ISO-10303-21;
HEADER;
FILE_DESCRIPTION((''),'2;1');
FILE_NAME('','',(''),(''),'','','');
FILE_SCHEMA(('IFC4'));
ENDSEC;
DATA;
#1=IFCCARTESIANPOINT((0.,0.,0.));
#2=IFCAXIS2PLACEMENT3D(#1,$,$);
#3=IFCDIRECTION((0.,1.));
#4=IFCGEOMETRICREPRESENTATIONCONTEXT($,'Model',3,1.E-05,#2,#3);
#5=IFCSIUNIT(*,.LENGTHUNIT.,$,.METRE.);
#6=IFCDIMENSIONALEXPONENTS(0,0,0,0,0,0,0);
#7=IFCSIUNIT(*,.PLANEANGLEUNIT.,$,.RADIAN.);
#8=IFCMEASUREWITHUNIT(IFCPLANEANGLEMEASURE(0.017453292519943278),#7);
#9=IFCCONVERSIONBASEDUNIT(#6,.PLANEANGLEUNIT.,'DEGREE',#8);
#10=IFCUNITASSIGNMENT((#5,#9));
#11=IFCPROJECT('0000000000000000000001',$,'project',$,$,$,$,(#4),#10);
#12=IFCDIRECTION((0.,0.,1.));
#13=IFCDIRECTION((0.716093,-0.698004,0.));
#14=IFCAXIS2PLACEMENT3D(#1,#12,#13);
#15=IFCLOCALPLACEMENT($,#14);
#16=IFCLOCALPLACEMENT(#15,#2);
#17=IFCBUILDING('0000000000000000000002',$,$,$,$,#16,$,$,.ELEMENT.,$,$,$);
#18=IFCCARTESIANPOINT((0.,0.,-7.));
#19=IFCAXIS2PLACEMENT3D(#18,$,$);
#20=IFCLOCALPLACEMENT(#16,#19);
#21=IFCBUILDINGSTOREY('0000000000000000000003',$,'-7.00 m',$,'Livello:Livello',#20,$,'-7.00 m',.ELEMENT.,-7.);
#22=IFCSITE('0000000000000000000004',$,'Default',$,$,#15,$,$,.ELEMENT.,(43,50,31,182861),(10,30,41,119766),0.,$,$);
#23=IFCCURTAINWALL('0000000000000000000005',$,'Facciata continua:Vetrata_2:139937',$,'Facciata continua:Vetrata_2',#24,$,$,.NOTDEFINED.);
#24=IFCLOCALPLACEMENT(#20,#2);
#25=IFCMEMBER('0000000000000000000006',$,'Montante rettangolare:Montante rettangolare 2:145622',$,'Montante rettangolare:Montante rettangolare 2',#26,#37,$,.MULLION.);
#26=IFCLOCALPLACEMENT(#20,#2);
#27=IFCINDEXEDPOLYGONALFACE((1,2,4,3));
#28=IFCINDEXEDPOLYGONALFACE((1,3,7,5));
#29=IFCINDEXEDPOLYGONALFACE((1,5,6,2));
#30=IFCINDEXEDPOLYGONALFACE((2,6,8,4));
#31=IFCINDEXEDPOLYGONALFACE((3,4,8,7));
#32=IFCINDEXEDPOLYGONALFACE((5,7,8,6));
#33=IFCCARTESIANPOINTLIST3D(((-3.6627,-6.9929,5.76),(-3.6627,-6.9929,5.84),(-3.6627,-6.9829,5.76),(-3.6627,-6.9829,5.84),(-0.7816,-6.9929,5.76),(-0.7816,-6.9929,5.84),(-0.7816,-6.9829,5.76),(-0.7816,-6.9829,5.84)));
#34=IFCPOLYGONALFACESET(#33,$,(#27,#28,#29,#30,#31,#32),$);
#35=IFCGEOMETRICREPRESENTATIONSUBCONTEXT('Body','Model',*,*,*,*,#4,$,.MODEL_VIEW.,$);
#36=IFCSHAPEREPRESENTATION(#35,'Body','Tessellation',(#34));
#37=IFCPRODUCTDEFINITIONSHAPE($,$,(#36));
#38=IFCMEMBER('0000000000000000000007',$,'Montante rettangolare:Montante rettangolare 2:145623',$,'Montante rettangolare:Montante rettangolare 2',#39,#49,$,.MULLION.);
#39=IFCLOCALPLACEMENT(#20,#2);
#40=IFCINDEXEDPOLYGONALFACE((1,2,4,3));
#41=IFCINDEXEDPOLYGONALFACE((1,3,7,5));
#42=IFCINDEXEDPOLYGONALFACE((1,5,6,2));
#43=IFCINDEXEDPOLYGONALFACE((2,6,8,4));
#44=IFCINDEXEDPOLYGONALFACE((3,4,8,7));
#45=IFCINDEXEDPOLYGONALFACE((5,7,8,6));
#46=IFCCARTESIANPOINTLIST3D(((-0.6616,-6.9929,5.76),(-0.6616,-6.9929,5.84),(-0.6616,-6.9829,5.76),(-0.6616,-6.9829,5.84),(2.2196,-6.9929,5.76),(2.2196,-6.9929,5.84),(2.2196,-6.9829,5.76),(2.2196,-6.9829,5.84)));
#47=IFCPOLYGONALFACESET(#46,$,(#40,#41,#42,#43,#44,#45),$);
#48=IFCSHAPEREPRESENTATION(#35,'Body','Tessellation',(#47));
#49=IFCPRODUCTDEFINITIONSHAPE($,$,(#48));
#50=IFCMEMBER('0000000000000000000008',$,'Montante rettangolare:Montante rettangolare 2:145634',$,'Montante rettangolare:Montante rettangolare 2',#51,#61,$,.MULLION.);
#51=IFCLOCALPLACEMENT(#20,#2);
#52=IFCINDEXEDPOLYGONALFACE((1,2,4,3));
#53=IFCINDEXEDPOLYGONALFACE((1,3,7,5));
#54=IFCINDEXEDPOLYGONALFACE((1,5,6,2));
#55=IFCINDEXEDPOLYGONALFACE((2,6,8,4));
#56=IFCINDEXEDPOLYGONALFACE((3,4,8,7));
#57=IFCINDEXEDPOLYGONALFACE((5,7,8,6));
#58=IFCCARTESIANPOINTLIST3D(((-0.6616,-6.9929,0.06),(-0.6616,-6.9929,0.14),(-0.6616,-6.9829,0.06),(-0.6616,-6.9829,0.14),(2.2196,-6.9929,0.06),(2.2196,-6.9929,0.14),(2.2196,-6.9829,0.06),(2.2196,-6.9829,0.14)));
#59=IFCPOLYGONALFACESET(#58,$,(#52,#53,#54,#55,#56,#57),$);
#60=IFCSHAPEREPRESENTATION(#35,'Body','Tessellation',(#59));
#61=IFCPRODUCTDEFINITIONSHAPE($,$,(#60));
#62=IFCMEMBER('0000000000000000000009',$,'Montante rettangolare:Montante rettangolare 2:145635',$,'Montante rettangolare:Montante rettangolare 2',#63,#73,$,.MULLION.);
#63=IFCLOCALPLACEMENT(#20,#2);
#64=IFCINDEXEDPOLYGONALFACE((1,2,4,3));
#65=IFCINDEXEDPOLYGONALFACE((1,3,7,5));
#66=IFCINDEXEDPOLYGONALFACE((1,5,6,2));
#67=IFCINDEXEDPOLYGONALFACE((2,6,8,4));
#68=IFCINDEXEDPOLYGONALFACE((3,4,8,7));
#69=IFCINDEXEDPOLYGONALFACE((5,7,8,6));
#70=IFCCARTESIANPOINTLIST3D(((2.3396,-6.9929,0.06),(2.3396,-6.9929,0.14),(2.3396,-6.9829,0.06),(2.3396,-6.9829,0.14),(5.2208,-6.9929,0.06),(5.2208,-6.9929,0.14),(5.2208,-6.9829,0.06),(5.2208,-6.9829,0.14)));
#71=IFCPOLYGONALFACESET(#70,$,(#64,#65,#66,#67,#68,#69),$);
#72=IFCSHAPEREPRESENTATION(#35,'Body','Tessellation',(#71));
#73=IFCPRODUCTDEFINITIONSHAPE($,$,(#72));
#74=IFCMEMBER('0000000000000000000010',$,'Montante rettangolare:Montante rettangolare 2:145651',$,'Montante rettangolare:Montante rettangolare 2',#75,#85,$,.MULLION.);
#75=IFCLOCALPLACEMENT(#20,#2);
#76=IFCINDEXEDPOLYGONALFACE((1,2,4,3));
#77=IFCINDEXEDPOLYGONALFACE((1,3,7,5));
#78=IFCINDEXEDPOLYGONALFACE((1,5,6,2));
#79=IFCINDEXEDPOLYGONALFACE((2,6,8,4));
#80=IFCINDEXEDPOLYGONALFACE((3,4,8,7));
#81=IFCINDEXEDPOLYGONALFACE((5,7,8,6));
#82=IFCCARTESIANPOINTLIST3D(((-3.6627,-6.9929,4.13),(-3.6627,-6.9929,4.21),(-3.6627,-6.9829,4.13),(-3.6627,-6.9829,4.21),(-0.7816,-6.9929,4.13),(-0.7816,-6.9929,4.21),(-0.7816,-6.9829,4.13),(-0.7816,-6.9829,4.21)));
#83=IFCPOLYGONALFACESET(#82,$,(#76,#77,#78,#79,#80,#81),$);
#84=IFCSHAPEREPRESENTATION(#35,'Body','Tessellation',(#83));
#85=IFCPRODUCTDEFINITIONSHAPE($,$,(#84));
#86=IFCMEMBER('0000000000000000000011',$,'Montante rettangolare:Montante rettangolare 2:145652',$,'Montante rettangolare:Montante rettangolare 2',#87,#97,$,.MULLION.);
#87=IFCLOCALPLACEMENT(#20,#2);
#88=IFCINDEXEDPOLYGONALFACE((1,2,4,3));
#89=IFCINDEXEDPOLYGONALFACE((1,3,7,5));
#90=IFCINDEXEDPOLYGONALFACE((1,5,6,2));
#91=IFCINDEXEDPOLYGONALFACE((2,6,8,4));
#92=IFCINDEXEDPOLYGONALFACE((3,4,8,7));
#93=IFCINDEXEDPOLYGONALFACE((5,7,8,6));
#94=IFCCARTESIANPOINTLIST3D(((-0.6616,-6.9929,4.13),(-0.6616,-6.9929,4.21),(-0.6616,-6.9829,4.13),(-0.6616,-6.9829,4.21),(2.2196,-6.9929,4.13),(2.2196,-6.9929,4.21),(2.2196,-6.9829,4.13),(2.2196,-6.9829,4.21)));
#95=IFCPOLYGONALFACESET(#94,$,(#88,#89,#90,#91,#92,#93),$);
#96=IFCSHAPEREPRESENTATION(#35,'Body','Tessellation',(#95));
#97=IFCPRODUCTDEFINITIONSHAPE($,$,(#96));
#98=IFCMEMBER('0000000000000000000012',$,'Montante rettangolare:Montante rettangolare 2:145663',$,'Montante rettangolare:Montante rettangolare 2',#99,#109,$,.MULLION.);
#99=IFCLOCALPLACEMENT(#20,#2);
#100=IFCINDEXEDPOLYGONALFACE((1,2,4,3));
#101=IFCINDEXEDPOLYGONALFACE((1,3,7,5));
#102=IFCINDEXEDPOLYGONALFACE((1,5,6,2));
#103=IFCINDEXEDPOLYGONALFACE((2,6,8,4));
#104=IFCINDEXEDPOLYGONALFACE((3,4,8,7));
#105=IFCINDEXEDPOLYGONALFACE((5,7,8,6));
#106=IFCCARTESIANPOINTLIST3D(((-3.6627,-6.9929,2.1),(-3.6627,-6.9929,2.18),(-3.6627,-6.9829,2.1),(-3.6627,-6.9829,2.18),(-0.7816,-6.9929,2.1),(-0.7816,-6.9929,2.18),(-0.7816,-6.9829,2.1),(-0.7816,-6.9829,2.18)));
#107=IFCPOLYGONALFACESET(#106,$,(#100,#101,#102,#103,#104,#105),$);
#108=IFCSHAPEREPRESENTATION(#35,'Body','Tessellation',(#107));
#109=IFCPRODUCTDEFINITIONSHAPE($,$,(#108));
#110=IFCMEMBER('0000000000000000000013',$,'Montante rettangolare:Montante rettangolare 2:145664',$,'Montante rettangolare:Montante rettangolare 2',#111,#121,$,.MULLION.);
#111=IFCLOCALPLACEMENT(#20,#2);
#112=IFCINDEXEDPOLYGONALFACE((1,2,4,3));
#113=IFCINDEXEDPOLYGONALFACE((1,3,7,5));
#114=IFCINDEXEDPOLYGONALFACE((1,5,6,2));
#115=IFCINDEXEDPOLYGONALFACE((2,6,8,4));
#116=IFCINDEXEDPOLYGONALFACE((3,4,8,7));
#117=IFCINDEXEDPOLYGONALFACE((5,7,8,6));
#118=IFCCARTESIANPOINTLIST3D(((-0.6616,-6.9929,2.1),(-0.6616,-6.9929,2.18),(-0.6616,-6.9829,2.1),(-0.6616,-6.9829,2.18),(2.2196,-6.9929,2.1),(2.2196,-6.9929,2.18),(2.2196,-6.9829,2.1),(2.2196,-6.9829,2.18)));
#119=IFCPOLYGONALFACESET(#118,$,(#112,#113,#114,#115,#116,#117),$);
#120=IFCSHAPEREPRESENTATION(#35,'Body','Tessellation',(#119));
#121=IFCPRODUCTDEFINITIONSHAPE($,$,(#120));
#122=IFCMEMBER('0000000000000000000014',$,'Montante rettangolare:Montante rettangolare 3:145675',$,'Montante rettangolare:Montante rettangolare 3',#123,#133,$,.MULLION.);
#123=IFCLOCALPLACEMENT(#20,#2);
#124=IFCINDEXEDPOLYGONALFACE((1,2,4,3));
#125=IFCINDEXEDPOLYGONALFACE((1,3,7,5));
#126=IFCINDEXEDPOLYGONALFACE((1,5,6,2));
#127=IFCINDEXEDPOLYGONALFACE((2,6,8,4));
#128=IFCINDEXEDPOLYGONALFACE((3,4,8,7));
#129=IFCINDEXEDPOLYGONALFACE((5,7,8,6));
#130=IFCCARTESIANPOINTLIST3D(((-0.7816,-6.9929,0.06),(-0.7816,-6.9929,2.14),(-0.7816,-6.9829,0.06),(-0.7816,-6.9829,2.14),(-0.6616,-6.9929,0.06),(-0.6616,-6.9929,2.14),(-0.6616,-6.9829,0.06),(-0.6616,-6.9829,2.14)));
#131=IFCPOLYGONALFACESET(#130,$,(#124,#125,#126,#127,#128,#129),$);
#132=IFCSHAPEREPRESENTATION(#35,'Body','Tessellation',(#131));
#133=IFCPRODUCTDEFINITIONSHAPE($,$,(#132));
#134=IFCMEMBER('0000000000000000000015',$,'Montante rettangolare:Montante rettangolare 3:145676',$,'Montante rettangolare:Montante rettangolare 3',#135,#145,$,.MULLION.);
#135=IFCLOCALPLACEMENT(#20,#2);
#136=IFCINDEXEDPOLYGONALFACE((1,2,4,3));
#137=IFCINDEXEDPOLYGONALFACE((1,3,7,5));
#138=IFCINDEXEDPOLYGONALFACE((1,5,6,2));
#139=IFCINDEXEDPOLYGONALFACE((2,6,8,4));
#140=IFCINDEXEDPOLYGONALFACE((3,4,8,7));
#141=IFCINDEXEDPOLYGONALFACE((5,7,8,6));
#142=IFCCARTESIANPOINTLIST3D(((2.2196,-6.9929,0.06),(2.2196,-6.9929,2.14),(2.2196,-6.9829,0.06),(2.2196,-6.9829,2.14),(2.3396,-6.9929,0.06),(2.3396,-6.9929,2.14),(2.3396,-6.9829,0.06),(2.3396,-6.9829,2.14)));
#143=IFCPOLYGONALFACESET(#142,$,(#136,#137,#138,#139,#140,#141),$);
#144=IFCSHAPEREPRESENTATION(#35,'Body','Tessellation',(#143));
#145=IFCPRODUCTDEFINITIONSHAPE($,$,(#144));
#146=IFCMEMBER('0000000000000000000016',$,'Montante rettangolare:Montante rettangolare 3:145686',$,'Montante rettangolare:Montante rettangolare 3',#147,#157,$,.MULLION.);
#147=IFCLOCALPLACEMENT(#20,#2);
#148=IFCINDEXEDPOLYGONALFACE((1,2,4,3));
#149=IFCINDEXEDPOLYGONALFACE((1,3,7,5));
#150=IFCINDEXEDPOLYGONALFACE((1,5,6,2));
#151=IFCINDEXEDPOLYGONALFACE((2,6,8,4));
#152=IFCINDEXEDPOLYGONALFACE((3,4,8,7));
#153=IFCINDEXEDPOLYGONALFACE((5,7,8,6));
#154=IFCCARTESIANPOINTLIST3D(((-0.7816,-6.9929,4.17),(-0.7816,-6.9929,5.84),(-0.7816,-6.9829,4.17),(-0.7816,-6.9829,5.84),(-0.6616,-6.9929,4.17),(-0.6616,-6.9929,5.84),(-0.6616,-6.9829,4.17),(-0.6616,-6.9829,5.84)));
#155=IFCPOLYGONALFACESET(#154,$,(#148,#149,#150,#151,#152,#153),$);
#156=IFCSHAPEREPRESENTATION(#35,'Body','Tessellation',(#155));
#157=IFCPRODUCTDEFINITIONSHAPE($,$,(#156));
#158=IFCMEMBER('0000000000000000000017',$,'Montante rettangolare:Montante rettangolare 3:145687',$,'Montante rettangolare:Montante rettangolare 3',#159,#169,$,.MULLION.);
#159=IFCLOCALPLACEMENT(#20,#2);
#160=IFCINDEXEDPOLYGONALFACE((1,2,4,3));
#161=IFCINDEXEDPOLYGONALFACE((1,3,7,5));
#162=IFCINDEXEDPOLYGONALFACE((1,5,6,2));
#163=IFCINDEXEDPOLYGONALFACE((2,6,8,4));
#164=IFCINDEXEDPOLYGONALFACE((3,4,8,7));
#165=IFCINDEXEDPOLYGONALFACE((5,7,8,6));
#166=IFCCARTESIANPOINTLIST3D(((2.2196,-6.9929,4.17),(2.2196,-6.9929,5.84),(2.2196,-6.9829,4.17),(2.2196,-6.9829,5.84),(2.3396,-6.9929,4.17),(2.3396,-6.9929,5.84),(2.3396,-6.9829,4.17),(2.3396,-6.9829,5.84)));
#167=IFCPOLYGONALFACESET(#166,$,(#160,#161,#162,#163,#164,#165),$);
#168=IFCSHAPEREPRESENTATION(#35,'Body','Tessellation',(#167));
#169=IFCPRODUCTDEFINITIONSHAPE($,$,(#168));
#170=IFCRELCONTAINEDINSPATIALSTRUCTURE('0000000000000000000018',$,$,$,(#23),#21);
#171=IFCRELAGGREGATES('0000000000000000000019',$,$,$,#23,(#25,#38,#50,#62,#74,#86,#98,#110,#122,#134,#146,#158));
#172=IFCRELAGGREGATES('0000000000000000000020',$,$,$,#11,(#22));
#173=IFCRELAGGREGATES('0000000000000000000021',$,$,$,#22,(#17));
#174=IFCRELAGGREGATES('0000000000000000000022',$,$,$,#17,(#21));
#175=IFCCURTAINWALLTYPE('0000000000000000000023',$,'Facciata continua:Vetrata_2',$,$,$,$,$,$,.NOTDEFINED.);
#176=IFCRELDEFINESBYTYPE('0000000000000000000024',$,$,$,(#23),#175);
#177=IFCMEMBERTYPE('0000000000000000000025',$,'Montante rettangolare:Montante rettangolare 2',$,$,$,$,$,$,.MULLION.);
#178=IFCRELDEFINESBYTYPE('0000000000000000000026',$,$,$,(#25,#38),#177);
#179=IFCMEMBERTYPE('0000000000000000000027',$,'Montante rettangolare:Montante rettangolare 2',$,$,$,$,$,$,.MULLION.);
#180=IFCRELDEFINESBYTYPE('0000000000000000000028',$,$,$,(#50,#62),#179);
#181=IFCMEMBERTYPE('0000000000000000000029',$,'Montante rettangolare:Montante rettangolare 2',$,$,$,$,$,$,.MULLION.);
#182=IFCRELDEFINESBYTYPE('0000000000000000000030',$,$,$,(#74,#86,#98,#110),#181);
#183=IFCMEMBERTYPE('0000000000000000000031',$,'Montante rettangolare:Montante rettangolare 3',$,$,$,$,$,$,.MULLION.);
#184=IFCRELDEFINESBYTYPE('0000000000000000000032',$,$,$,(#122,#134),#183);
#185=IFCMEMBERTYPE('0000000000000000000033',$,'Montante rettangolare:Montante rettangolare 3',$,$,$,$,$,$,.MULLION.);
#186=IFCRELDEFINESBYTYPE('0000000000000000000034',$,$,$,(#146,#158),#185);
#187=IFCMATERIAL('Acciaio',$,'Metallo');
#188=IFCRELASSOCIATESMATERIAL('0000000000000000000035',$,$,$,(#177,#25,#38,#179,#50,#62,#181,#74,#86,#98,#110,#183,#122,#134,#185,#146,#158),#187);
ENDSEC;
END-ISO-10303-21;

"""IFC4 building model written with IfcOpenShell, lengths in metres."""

from ifc_helpers import new_model, entity, si_unit, converted_unit, direction, frame, origin, place, context, subcontext, project, spatial, indexed_curve, outline, extrude, source, transform, mapped, material, type_object, type_shapes, element, aggregate, save


model = new_model("IFC4")

# Units and contexts
model_context = context("Model", 3, precision=1e-05, world=origin(), true_north=direction((0.0, 1.0)))
body_context = subcontext(model_context, "Body", "Model", "MODEL_VIEW")
ifc_project = project(units=[si_unit("LENGTHUNIT", "METRE"), converted_unit("PLANEANGLEUNIT", "DEGREE", entity("IfcPlaneAngleMeasure", 0.017453292519943278), si_unit("PLANEANGLEUNIT", "RADIAN"), dimensions=[0, 0, 0, 0, 0, 0, 0])], contexts=[model_context])

# Site, building, storey
site_placement = place(None, frame((0.0, 0.0, 0.0), z_axis=(0.0, 0.0, 1.0), x_axis=(0.716093, -0.698004, 0.0)))
site = spatial("IfcSite", under=ifc_project, at=site_placement, Name="Default", CompositionType="ELEMENT", RefLatitude=(43, 50, 31, 182861), RefLongitude=(10, 30, 41, 119766), RefElevation=0.0)
building_placement = place(site_placement, origin())
building = spatial("IfcBuilding", under=site, at=building_placement, CompositionType="ELEMENT")
storey_placement = place(building_placement, frame((0.0, 0.0, -7.0)))
storey = spatial("IfcBuildingStorey", under=building, at=storey_placement, Name="-7.00 m", ObjectType="Livello:Livello", LongName="-7.00 m", CompositionType="ELEMENT", Elevation=-7.0)

# Curtain wall, members
curtain_wall_type = type_object("IfcCurtainWallType", Name="Facciata continua:Vetrata_2", PredefinedType="NOTDEFINED")
curtain_wall_placement = place(storey_placement, frame((0.0, 0.0, 7.0)))
curtain_wall = element("IfcCurtainWall", 1, at=curtain_wall_placement, inside=storey, type_object=curtain_wall_type, Name="Facciata continua:Vetrata_2:139937", ObjectType="Facciata continua:Vetrata_2", PredefinedType="NOTDEFINED")
ifc_material_1 = material(Name="Acciaio", Category="Metallo")
member_type_1 = type_object("IfcMemberType", Name="Montante rettangolare:Montante rettangolare 2", PredefinedType="MULLION", material=ifc_material_1)
shared_shape_1 = source(origin(), body_context, "Body", "SweptSolid", [
    extrude(outline(indexed_curve([(-0.04, -0.005), (0.04, -0.005), (0.04, 0.005), (-0.04, 0.005), (-0.04, -0.005)], self_intersect=False)), frame((-0.04, 0.01, -2.8812), z_axis=(0.0, 0.0, 1.0), x_axis=(-1.0, 0.0, 0.0)), (0.0, 0.0, 1.0), 2.8812),
])
type_shapes(member_type_1, [shared_shape_1])
member_1_placement = place(curtain_wall_placement, frame((-0.7816, -6.9779, -1.16), z_axis=(1.0, 0.0, 0.0), x_axis=(0.0, 0.0, 1.0)))
member_1 = element("IfcMember", 2, at=member_1_placement, type_object=member_type_1, material=ifc_material_1, Name="Montante rettangolare:Montante rettangolare 2:145622", ObjectType="Montante rettangolare:Montante rettangolare 2", PredefinedType="MULLION", context=body_context, shape_type="MappedRepresentation", body=[
    mapped(shared_shape_1, transform((0.0, 0.0, 0.0), scale=1.0)),
])
member_2_placement = place(curtain_wall_placement, frame((2.2196, -6.9779, -1.16), z_axis=(1.0, 0.0, 0.0), x_axis=(0.0, 0.0, 1.0)))
member_2 = element("IfcMember", 3, at=member_2_placement, type_object=member_type_1, material=ifc_material_1, Name="Montante rettangolare:Montante rettangolare 2:145623", ObjectType="Montante rettangolare:Montante rettangolare 2", PredefinedType="MULLION", context=body_context, shape_type="MappedRepresentation", body=[
    mapped(shared_shape_1, transform((0.0, 0.0, 0.0), scale=1.0)),
])
member_type_2 = type_object("IfcMemberType", Name="Montante rettangolare:Montante rettangolare 2", PredefinedType="MULLION", material=ifc_material_1)
shared_shape_2 = source(origin(), body_context, "Body", "SweptSolid", [
    extrude(outline(indexed_curve([(-0.04, -0.005), (0.04, -0.005), (0.04, 0.005), (-0.04, 0.005), (-0.04, -0.005)], self_intersect=False)), frame((-0.04, 0.01, -2.8812), z_axis=(0.0, 0.0, 1.0), x_axis=(-1.0, 0.0, 0.0)), (0.0, 0.0, 1.0), 2.8812),
])
type_shapes(member_type_2, [shared_shape_2])
member_3_placement = place(curtain_wall_placement, frame((-0.6616, -6.9779, -6.94), z_axis=(-1.0, 0.0, 0.0), x_axis=(0.0, 0.0, -1.0)))
member_3 = element("IfcMember", 4, at=member_3_placement, type_object=member_type_2, material=ifc_material_1, Name="Montante rettangolare:Montante rettangolare 2:145634", ObjectType="Montante rettangolare:Montante rettangolare 2", PredefinedType="MULLION", context=body_context, shape_type="MappedRepresentation", body=[
    mapped(shared_shape_2, transform((0.0, 0.0, 0.0), scale=1.0)),
])
member_4_placement = place(curtain_wall_placement, frame((2.3396, -6.9779, -6.94), z_axis=(-1.0, 0.0, 0.0), x_axis=(0.0, 0.0, -1.0)))
member_4 = element("IfcMember", 5, at=member_4_placement, type_object=member_type_2, material=ifc_material_1, Name="Montante rettangolare:Montante rettangolare 2:145635", ObjectType="Montante rettangolare:Montante rettangolare 2", PredefinedType="MULLION", context=body_context, shape_type="MappedRepresentation", body=[
    mapped(shared_shape_2, transform((0.0, 0.0, 0.0), scale=1.0)),
])
member_type_3 = type_object("IfcMemberType", Name="Montante rettangolare:Montante rettangolare 2", PredefinedType="MULLION", material=ifc_material_1)
shared_shape_3 = source(origin(), body_context, "Body", "SweptSolid", [
    extrude(outline(indexed_curve([(-0.04, -0.005), (0.04, -0.005), (0.04, 0.005), (-0.04, 0.005), (-0.04, -0.005)], self_intersect=False)), frame((0.0, 0.01, -2.8812), z_axis=(0.0, 0.0, 1.0), x_axis=(-1.0, 0.0, 0.0)), (0.0, 0.0, 1.0), 2.8812),
])
type_shapes(member_type_3, [shared_shape_3])
member_5_placement = place(curtain_wall_placement, frame((-0.7816, -6.9779, -2.83), z_axis=(1.0, 0.0, 0.0), x_axis=(0.0, 0.0, 1.0)))
member_5 = element("IfcMember", 6, at=member_5_placement, type_object=member_type_3, material=ifc_material_1, Name="Montante rettangolare:Montante rettangolare 2:145651", ObjectType="Montante rettangolare:Montante rettangolare 2", PredefinedType="MULLION", context=body_context, shape_type="MappedRepresentation", body=[
    mapped(shared_shape_3, transform((0.0, 0.0, 0.0), scale=1.0)),
])
member_6_placement = place(curtain_wall_placement, frame((2.2196, -6.9779, -2.83), z_axis=(1.0, 0.0, 0.0), x_axis=(0.0, 0.0, 1.0)))
member_6 = element("IfcMember", 7, at=member_6_placement, type_object=member_type_3, material=ifc_material_1, Name="Montante rettangolare:Montante rettangolare 2:145652", ObjectType="Montante rettangolare:Montante rettangolare 2", PredefinedType="MULLION", context=body_context, shape_type="MappedRepresentation", body=[
    mapped(shared_shape_3, transform((0.0, 0.0, 0.0), scale=1.0)),
])
member_7_placement = place(curtain_wall_placement, frame((-0.7816, -6.9779, -4.86), z_axis=(1.0, 0.0, 0.0), x_axis=(0.0, 0.0, 1.0)))
member_7 = element("IfcMember", 8, at=member_7_placement, type_object=member_type_3, material=ifc_material_1, Name="Montante rettangolare:Montante rettangolare 2:145663", ObjectType="Montante rettangolare:Montante rettangolare 2", PredefinedType="MULLION", context=body_context, shape_type="MappedRepresentation", body=[
    mapped(shared_shape_3, transform((0.0, 0.0, 0.0), scale=1.0)),
])
member_8_placement = place(curtain_wall_placement, frame((2.2196, -6.9779, -4.86), z_axis=(1.0, 0.0, 0.0), x_axis=(0.0, 0.0, 1.0)))
member_8 = element("IfcMember", 9, at=member_8_placement, type_object=member_type_3, material=ifc_material_1, Name="Montante rettangolare:Montante rettangolare 2:145664", ObjectType="Montante rettangolare:Montante rettangolare 2", PredefinedType="MULLION", context=body_context, shape_type="MappedRepresentation", body=[
    mapped(shared_shape_3, transform((0.0, 0.0, 0.0), scale=1.0)),
])
member_type_4 = type_object("IfcMemberType", Name="Montante rettangolare:Montante rettangolare 3", PredefinedType="MULLION", material=ifc_material_1)
shared_shape_4 = source(origin(), body_context, "Body", "SweptSolid", [
    extrude(outline(indexed_curve([(-0.06, -0.005), (0.06, -0.005), (0.06, 0.005), (-0.06, 0.005), (-0.06, -0.005)], self_intersect=False)), frame((0.0, 0.01, -2.08), z_axis=(0.0, 0.0, 1.0), x_axis=(-1.0, 0.0, 0.0)), (0.0, 0.0, 1.0), 2.08),
])
type_shapes(member_type_4, [shared_shape_4])
member_9_placement = place(curtain_wall_placement, frame((-0.7216, -6.9779, -6.94), z_axis=(0.0, 0.0, -1.0), x_axis=(1.0, 0.0, 0.0)))
member_9 = element("IfcMember", 10, at=member_9_placement, type_object=member_type_4, material=ifc_material_1, Name="Montante rettangolare:Montante rettangolare 3:145675", ObjectType="Montante rettangolare:Montante rettangolare 3", PredefinedType="MULLION", context=body_context, shape_type="MappedRepresentation", body=[
    mapped(shared_shape_4, transform((0.0, 0.0, 0.0), scale=1.0)),
])
member_10_placement = place(curtain_wall_placement, frame((2.2796, -6.9779, -6.94), z_axis=(0.0, 0.0, -1.0), x_axis=(1.0, 0.0, 0.0)))
member_10 = element("IfcMember", 11, at=member_10_placement, type_object=member_type_4, material=ifc_material_1, Name="Montante rettangolare:Montante rettangolare 3:145676", ObjectType="Montante rettangolare:Montante rettangolare 3", PredefinedType="MULLION", context=body_context, shape_type="MappedRepresentation", body=[
    mapped(shared_shape_4, transform((0.0, 0.0, 0.0), scale=1.0)),
])
member_type_5 = type_object("IfcMemberType", Name="Montante rettangolare:Montante rettangolare 3", PredefinedType="MULLION", material=ifc_material_1)
shared_shape_5 = source(origin(), body_context, "Body", "SweptSolid", [
    extrude(outline(indexed_curve([(-0.06, -0.005), (0.06, -0.005), (0.06, 0.005), (-0.06, 0.005), (-0.06, -0.005)], self_intersect=False)), frame((0.0, 0.01, -1.67), z_axis=(0.0, 0.0, 1.0), x_axis=(-1.0, 0.0, 0.0)), (0.0, 0.0, 1.0), 1.67),
])
type_shapes(member_type_5, [shared_shape_5])
member_11_placement = place(curtain_wall_placement, frame((-0.7216, -6.9779, -2.83), z_axis=(0.0, 0.0, -1.0), x_axis=(1.0, 0.0, 0.0)))
member_11 = element("IfcMember", 12, at=member_11_placement, type_object=member_type_5, material=ifc_material_1, Name="Montante rettangolare:Montante rettangolare 3:145686", ObjectType="Montante rettangolare:Montante rettangolare 3", PredefinedType="MULLION", context=body_context, shape_type="MappedRepresentation", body=[
    mapped(shared_shape_5, transform((0.0, 0.0, 0.0), scale=1.0)),
])
member_12_placement = place(curtain_wall_placement, frame((2.2796, -6.9779, -2.83), z_axis=(0.0, 0.0, -1.0), x_axis=(1.0, 0.0, 0.0)))
member_12 = element("IfcMember", 13, at=member_12_placement, type_object=member_type_5, material=ifc_material_1, Name="Montante rettangolare:Montante rettangolare 3:145687", ObjectType="Montante rettangolare:Montante rettangolare 3", PredefinedType="MULLION", context=body_context, shape_type="MappedRepresentation", body=[
    mapped(shared_shape_5, transform((0.0, 0.0, 0.0), scale=1.0)),
])
aggregate(curtain_wall, [member_1, member_2, member_3, member_4, member_5, member_6, member_7, member_8, member_9, member_10, member_11, member_12])

save(model, "model.ifc")
